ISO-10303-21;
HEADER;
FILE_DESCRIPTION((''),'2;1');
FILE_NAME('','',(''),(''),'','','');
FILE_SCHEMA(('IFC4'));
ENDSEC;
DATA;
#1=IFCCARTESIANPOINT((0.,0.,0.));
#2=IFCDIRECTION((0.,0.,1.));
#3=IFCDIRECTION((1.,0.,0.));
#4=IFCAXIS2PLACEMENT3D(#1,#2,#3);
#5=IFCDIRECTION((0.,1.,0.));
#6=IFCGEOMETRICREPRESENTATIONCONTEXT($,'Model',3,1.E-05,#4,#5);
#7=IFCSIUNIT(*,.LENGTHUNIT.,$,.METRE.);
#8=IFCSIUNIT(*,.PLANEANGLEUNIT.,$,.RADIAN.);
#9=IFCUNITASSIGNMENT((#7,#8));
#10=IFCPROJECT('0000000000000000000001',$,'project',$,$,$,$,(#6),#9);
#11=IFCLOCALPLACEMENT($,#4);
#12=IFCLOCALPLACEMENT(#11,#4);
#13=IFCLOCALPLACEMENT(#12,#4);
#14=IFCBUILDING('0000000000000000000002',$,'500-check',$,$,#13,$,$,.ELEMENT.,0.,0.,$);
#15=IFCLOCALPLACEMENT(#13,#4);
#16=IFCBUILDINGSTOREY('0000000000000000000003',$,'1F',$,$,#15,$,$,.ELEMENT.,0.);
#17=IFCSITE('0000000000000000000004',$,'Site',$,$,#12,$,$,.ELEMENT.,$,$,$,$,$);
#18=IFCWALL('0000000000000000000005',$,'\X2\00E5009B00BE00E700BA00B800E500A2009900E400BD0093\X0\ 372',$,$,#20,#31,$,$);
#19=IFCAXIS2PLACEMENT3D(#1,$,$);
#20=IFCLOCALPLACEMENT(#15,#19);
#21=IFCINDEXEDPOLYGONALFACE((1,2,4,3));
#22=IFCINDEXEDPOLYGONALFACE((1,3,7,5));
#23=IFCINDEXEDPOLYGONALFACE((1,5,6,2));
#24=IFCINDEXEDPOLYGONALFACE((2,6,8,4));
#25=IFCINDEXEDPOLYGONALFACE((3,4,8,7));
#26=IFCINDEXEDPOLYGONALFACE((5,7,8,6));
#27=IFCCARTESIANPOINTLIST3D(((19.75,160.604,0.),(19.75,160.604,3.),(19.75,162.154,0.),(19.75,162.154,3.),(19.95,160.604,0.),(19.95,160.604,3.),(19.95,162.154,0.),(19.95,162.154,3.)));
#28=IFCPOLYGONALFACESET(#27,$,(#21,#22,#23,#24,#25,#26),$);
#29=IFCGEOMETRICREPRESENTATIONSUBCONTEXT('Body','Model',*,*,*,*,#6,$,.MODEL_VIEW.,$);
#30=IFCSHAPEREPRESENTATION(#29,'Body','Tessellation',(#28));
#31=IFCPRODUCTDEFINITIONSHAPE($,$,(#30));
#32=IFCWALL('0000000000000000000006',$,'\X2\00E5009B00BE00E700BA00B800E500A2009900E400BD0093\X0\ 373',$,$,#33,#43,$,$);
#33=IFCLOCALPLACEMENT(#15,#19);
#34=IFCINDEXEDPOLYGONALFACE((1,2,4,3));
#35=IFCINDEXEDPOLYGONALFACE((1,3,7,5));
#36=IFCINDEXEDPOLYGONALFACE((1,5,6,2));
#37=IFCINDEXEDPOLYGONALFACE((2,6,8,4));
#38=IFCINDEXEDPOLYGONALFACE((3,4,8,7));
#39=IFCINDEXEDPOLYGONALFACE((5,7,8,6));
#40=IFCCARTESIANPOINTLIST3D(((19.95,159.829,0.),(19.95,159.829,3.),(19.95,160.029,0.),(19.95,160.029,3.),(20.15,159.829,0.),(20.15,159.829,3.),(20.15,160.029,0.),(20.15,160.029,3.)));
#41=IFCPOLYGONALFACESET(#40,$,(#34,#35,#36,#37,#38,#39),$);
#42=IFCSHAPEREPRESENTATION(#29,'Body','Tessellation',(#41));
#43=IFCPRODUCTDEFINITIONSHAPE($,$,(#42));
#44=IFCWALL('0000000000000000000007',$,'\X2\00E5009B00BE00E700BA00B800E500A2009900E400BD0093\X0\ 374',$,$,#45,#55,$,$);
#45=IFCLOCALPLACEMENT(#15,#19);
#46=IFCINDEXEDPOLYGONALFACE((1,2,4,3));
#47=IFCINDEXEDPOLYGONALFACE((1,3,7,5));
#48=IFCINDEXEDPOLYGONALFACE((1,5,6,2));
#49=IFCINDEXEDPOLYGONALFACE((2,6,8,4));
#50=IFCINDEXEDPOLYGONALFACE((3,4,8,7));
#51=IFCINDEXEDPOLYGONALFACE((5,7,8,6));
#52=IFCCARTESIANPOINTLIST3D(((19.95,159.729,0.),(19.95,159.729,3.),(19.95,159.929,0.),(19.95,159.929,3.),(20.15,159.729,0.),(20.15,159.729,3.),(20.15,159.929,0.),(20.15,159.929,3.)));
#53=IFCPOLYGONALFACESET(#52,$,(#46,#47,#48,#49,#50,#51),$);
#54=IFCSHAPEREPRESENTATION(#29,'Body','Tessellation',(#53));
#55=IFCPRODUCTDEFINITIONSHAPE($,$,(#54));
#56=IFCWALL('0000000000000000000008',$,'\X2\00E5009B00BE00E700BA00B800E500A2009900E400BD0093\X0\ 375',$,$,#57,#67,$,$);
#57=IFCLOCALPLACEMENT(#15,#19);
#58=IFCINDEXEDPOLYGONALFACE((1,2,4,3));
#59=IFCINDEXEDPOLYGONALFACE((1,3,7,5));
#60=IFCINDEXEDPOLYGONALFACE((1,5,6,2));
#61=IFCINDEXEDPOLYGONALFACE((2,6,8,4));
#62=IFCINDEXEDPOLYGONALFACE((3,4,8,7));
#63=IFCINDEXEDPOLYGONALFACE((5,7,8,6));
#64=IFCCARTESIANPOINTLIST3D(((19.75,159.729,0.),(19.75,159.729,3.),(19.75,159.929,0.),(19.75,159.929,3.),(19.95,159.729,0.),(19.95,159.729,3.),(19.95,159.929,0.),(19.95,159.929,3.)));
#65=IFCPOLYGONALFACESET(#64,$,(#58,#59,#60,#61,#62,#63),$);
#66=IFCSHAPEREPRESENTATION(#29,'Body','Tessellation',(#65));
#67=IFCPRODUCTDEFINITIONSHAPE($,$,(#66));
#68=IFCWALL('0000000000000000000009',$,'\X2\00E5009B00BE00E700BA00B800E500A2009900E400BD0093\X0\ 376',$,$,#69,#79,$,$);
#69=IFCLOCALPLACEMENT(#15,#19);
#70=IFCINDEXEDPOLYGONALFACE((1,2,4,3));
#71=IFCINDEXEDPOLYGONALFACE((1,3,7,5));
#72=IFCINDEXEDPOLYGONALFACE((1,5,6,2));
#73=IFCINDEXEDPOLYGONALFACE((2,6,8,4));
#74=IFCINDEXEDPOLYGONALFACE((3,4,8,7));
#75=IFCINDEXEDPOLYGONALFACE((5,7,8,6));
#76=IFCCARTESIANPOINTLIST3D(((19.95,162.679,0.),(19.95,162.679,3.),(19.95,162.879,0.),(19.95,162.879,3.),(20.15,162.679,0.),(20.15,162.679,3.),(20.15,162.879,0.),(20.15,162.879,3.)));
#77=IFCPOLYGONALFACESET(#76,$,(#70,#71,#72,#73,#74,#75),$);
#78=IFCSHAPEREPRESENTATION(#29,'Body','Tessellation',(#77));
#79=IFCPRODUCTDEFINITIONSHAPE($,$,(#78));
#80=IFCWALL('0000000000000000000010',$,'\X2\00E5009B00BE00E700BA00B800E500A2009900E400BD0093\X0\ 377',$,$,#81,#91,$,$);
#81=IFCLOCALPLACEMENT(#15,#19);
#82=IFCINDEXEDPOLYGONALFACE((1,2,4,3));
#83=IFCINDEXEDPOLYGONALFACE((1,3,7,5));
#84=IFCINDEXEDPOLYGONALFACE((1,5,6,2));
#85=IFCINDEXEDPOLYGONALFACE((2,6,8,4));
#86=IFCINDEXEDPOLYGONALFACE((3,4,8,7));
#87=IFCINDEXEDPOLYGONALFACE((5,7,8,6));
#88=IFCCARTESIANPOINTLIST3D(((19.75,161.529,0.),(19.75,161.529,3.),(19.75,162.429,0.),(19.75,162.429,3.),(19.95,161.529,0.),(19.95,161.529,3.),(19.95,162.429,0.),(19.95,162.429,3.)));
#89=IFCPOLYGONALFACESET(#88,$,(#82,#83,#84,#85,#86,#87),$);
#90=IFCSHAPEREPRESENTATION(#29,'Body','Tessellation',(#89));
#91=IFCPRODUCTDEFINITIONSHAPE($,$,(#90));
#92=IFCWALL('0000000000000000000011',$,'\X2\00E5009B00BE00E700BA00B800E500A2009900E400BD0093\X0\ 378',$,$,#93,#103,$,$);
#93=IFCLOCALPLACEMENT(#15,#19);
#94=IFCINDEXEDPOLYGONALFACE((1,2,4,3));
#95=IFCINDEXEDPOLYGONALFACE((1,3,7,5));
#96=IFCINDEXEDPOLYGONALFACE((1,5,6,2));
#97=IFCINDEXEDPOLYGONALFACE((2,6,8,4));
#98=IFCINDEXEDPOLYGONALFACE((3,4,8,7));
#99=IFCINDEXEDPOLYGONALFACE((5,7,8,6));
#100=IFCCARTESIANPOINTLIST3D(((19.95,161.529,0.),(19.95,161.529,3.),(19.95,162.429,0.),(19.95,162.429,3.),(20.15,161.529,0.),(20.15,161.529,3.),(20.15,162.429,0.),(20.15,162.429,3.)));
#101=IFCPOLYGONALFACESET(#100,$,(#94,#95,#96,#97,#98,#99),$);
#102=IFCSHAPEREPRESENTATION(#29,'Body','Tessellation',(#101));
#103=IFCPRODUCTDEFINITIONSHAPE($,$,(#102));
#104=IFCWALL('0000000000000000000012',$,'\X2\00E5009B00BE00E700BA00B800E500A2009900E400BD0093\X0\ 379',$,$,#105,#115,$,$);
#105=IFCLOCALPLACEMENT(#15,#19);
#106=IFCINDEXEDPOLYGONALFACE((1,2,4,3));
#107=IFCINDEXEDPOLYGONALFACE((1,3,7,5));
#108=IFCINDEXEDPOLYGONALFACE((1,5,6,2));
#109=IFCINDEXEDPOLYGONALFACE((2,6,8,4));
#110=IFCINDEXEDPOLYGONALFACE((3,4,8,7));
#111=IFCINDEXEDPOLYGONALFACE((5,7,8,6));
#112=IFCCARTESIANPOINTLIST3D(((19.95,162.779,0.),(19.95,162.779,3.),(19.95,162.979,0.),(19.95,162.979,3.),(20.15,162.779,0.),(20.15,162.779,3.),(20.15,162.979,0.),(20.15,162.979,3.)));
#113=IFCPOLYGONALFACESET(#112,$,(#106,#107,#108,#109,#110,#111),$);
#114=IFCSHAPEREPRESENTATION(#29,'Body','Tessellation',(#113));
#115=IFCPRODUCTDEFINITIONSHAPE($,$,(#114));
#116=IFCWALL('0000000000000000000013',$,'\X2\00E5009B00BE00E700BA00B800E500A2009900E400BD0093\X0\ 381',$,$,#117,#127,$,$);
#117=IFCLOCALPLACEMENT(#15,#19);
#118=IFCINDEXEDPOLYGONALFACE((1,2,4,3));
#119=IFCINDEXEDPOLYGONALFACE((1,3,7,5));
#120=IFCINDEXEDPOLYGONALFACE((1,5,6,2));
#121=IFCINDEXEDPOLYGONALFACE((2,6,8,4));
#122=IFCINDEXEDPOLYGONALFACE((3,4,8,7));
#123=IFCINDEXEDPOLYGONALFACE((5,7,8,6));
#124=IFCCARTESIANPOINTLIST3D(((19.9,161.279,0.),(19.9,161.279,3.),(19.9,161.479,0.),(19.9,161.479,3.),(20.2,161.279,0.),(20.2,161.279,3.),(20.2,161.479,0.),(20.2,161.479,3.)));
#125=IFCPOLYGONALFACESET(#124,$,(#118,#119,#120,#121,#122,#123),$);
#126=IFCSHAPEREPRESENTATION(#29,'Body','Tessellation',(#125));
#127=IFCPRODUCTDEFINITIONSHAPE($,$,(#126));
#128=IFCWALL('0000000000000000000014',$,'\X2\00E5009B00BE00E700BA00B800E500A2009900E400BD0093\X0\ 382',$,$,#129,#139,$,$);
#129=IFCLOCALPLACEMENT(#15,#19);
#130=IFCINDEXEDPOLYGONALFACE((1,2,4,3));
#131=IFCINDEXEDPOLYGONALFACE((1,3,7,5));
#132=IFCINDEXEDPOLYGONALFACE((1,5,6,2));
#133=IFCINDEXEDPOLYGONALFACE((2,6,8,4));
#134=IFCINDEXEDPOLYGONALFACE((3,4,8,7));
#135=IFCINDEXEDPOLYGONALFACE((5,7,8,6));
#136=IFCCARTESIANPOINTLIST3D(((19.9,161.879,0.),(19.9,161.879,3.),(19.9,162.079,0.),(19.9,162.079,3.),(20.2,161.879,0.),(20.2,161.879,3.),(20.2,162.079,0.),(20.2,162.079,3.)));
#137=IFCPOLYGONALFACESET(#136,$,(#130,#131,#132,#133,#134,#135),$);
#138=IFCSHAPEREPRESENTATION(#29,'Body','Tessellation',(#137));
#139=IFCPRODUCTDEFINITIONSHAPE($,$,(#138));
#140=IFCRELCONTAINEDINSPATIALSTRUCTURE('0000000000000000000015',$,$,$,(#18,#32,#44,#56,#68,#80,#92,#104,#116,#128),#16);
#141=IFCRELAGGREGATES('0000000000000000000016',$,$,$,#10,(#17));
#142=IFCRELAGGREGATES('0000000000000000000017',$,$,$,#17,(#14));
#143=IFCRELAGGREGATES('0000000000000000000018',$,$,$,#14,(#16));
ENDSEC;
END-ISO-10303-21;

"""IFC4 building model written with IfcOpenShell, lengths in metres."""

from ifc_helpers import new_model, si_unit, direction, frame, frame_2d, origin_with_axes, place, context, subcontext, project, spatial, rectangle, extrude, element, save


model = new_model("IFC4")

# Units and contexts
model_context = context("Model", 3, precision=1e-05, world=origin_with_axes(), true_north=direction((0.0, 1.0, 0.0)))
body_context = subcontext(model_context, "Body", "Model", "MODEL_VIEW")
ifc_project = project(units=[si_unit("LENGTHUNIT", "METRE"), si_unit("PLANEANGLEUNIT", "RADIAN")], contexts=[model_context])

# Site, building, storey
placement = place(None, origin_with_axes())
site_placement = place(placement, origin_with_axes())
site = spatial("IfcSite", under=ifc_project, at=site_placement, Name="Site", CompositionType="ELEMENT")
building_placement = place(site_placement, origin_with_axes())
building = spatial("IfcBuilding", under=site, at=building_placement, Name="500-check", CompositionType="ELEMENT", ElevationOfRefHeight=0.0, ElevationOfTerrain=0.0)
storey_placement = place(building_placement, origin_with_axes())
storey = spatial("IfcBuildingStorey", under=building, at=storey_placement, Name="1F", CompositionType="ELEMENT", Elevation=0.0)

# Walls
wall_1_placement = place(storey_placement, frame((19.85, 161.379, 0.0), z_axis=(0.0, 0.0, 1.0), x_axis=(0.0, -1.0, 0.0)))
element("IfcWall", 1, at=wall_1_placement, inside=storey, Name="å\u009b¾çº¸å¢\u0099ä½\u0093 372", context=body_context, shape_type="SweptSolid", body=[
    extrude(rectangle(XDim=1.55, YDim=0.2, at=frame_2d((0.0, 0.0), x_axis=(1.0, 0.0, 0.0))), frame((0.0, 0.0, 0.0), z_axis=(0.0, 0.0, 1.0)), (0.0, 0.0, 1.0), 3.0),
])
for number, where, z_axis, x_axis, name in (
    (2, (20.05, 159.929, 0.0), (0.0, 0.0, 1.0), (-1.0, 0.0, 0.0), "å\u009b¾çº¸å¢\u0099ä½\u0093 373"),
    (3, (20.05, 159.829, 0.0), (0.0, 0.0, 1.0), (-1.0, 0.0, 0.0), "å\u009b¾çº¸å¢\u0099ä½\u0093 374"),
    (4, (19.85, 159.829, 0.0), (0.0, 0.0, 1.0), (1.0, 0.0, 0.0), "å\u009b¾çº¸å¢\u0099ä½\u0093 375"),
    (5, (20.05, 162.779, 0.0), (0.0, 0.0, 1.0), (-1.0, 0.0, 0.0), "å\u009b¾çº¸å¢\u0099ä½\u0093 376"),
):
    element("IfcWall", number, at=place(storey_placement, frame(where, z_axis=z_axis, x_axis=x_axis)), inside=storey, Name=name, context=body_context, shape_type="SweptSolid", body=[
        extrude(rectangle(XDim=0.2, YDim=0.2, at=frame_2d((0.0, 0.0), x_axis=(1.0, 0.0, 0.0))), frame((0.0, 0.0, 0.0), z_axis=(0.0, 0.0, 1.0)), (0.0, 0.0, 1.0), 3.0),
    ])
for number, where, z_axis, x_axis, name in (
    (6, (19.85, 161.979, 0.0), (0.0, 0.0, 1.0), (0.0, 1.0, 0.0), "å\u009b¾çº¸å¢\u0099ä½\u0093 377"),
    (7, (20.05, 161.979, 0.0), (0.0, 0.0, 1.0), (0.0, 1.0, 0.0), "å\u009b¾çº¸å¢\u0099ä½\u0093 378"),
):
    element("IfcWall", number, at=place(storey_placement, frame(where, z_axis=z_axis, x_axis=x_axis)), inside=storey, Name=name, context=body_context, shape_type="SweptSolid", body=[
        extrude(rectangle(XDim=0.9, YDim=0.2, at=frame_2d((0.0, 0.0), x_axis=(1.0, 0.0, 0.0))), frame((0.0, 0.0, 0.0), z_axis=(0.0, 0.0, 1.0)), (0.0, 0.0, 1.0), 3.0),
    ])
wall_2_placement = place(storey_placement, frame((20.05, 162.879, 0.0), z_axis=(0.0, 0.0, 1.0), x_axis=(-1.0, 0.0, 0.0)))
element("IfcWall", 8, at=wall_2_placement, inside=storey, Name="å\u009b¾çº¸å¢\u0099ä½\u0093 379", context=body_context, shape_type="SweptSolid", body=[
    extrude(rectangle(XDim=0.2, YDim=0.2, at=frame_2d((0.0, 0.0), x_axis=(1.0, 0.0, 0.0))), frame((0.0, 0.0, 0.0), z_axis=(0.0, 0.0, 1.0)), (0.0, 0.0, 1.0), 3.0),
])
for number, where, z_axis, x_axis, name in (
    (9, (20.05, 161.379, 0.0), (0.0, 0.0, 1.0), (-1.0, 0.0, 0.0), "å\u009b¾çº¸å¢\u0099ä½\u0093 381"),
    (10, (20.05, 161.979, 0.0), (0.0, 0.0, 1.0), (-1.0, 0.0, 0.0), "å\u009b¾çº¸å¢\u0099ä½\u0093 382"),
):
    element("IfcWall", number, at=place(storey_placement, frame(where, z_axis=z_axis, x_axis=x_axis)), inside=storey, Name=name, context=body_context, shape_type="SweptSolid", body=[
        extrude(rectangle(XDim=0.3, YDim=0.2, at=frame_2d((0.0, 0.0), x_axis=(1.0, 0.0, 0.0))), frame((0.0, 0.0, 0.0), z_axis=(0.0, 0.0, 1.0)), (0.0, 0.0, 1.0), 3.0),
    ])

save(model, "model.ifc")
